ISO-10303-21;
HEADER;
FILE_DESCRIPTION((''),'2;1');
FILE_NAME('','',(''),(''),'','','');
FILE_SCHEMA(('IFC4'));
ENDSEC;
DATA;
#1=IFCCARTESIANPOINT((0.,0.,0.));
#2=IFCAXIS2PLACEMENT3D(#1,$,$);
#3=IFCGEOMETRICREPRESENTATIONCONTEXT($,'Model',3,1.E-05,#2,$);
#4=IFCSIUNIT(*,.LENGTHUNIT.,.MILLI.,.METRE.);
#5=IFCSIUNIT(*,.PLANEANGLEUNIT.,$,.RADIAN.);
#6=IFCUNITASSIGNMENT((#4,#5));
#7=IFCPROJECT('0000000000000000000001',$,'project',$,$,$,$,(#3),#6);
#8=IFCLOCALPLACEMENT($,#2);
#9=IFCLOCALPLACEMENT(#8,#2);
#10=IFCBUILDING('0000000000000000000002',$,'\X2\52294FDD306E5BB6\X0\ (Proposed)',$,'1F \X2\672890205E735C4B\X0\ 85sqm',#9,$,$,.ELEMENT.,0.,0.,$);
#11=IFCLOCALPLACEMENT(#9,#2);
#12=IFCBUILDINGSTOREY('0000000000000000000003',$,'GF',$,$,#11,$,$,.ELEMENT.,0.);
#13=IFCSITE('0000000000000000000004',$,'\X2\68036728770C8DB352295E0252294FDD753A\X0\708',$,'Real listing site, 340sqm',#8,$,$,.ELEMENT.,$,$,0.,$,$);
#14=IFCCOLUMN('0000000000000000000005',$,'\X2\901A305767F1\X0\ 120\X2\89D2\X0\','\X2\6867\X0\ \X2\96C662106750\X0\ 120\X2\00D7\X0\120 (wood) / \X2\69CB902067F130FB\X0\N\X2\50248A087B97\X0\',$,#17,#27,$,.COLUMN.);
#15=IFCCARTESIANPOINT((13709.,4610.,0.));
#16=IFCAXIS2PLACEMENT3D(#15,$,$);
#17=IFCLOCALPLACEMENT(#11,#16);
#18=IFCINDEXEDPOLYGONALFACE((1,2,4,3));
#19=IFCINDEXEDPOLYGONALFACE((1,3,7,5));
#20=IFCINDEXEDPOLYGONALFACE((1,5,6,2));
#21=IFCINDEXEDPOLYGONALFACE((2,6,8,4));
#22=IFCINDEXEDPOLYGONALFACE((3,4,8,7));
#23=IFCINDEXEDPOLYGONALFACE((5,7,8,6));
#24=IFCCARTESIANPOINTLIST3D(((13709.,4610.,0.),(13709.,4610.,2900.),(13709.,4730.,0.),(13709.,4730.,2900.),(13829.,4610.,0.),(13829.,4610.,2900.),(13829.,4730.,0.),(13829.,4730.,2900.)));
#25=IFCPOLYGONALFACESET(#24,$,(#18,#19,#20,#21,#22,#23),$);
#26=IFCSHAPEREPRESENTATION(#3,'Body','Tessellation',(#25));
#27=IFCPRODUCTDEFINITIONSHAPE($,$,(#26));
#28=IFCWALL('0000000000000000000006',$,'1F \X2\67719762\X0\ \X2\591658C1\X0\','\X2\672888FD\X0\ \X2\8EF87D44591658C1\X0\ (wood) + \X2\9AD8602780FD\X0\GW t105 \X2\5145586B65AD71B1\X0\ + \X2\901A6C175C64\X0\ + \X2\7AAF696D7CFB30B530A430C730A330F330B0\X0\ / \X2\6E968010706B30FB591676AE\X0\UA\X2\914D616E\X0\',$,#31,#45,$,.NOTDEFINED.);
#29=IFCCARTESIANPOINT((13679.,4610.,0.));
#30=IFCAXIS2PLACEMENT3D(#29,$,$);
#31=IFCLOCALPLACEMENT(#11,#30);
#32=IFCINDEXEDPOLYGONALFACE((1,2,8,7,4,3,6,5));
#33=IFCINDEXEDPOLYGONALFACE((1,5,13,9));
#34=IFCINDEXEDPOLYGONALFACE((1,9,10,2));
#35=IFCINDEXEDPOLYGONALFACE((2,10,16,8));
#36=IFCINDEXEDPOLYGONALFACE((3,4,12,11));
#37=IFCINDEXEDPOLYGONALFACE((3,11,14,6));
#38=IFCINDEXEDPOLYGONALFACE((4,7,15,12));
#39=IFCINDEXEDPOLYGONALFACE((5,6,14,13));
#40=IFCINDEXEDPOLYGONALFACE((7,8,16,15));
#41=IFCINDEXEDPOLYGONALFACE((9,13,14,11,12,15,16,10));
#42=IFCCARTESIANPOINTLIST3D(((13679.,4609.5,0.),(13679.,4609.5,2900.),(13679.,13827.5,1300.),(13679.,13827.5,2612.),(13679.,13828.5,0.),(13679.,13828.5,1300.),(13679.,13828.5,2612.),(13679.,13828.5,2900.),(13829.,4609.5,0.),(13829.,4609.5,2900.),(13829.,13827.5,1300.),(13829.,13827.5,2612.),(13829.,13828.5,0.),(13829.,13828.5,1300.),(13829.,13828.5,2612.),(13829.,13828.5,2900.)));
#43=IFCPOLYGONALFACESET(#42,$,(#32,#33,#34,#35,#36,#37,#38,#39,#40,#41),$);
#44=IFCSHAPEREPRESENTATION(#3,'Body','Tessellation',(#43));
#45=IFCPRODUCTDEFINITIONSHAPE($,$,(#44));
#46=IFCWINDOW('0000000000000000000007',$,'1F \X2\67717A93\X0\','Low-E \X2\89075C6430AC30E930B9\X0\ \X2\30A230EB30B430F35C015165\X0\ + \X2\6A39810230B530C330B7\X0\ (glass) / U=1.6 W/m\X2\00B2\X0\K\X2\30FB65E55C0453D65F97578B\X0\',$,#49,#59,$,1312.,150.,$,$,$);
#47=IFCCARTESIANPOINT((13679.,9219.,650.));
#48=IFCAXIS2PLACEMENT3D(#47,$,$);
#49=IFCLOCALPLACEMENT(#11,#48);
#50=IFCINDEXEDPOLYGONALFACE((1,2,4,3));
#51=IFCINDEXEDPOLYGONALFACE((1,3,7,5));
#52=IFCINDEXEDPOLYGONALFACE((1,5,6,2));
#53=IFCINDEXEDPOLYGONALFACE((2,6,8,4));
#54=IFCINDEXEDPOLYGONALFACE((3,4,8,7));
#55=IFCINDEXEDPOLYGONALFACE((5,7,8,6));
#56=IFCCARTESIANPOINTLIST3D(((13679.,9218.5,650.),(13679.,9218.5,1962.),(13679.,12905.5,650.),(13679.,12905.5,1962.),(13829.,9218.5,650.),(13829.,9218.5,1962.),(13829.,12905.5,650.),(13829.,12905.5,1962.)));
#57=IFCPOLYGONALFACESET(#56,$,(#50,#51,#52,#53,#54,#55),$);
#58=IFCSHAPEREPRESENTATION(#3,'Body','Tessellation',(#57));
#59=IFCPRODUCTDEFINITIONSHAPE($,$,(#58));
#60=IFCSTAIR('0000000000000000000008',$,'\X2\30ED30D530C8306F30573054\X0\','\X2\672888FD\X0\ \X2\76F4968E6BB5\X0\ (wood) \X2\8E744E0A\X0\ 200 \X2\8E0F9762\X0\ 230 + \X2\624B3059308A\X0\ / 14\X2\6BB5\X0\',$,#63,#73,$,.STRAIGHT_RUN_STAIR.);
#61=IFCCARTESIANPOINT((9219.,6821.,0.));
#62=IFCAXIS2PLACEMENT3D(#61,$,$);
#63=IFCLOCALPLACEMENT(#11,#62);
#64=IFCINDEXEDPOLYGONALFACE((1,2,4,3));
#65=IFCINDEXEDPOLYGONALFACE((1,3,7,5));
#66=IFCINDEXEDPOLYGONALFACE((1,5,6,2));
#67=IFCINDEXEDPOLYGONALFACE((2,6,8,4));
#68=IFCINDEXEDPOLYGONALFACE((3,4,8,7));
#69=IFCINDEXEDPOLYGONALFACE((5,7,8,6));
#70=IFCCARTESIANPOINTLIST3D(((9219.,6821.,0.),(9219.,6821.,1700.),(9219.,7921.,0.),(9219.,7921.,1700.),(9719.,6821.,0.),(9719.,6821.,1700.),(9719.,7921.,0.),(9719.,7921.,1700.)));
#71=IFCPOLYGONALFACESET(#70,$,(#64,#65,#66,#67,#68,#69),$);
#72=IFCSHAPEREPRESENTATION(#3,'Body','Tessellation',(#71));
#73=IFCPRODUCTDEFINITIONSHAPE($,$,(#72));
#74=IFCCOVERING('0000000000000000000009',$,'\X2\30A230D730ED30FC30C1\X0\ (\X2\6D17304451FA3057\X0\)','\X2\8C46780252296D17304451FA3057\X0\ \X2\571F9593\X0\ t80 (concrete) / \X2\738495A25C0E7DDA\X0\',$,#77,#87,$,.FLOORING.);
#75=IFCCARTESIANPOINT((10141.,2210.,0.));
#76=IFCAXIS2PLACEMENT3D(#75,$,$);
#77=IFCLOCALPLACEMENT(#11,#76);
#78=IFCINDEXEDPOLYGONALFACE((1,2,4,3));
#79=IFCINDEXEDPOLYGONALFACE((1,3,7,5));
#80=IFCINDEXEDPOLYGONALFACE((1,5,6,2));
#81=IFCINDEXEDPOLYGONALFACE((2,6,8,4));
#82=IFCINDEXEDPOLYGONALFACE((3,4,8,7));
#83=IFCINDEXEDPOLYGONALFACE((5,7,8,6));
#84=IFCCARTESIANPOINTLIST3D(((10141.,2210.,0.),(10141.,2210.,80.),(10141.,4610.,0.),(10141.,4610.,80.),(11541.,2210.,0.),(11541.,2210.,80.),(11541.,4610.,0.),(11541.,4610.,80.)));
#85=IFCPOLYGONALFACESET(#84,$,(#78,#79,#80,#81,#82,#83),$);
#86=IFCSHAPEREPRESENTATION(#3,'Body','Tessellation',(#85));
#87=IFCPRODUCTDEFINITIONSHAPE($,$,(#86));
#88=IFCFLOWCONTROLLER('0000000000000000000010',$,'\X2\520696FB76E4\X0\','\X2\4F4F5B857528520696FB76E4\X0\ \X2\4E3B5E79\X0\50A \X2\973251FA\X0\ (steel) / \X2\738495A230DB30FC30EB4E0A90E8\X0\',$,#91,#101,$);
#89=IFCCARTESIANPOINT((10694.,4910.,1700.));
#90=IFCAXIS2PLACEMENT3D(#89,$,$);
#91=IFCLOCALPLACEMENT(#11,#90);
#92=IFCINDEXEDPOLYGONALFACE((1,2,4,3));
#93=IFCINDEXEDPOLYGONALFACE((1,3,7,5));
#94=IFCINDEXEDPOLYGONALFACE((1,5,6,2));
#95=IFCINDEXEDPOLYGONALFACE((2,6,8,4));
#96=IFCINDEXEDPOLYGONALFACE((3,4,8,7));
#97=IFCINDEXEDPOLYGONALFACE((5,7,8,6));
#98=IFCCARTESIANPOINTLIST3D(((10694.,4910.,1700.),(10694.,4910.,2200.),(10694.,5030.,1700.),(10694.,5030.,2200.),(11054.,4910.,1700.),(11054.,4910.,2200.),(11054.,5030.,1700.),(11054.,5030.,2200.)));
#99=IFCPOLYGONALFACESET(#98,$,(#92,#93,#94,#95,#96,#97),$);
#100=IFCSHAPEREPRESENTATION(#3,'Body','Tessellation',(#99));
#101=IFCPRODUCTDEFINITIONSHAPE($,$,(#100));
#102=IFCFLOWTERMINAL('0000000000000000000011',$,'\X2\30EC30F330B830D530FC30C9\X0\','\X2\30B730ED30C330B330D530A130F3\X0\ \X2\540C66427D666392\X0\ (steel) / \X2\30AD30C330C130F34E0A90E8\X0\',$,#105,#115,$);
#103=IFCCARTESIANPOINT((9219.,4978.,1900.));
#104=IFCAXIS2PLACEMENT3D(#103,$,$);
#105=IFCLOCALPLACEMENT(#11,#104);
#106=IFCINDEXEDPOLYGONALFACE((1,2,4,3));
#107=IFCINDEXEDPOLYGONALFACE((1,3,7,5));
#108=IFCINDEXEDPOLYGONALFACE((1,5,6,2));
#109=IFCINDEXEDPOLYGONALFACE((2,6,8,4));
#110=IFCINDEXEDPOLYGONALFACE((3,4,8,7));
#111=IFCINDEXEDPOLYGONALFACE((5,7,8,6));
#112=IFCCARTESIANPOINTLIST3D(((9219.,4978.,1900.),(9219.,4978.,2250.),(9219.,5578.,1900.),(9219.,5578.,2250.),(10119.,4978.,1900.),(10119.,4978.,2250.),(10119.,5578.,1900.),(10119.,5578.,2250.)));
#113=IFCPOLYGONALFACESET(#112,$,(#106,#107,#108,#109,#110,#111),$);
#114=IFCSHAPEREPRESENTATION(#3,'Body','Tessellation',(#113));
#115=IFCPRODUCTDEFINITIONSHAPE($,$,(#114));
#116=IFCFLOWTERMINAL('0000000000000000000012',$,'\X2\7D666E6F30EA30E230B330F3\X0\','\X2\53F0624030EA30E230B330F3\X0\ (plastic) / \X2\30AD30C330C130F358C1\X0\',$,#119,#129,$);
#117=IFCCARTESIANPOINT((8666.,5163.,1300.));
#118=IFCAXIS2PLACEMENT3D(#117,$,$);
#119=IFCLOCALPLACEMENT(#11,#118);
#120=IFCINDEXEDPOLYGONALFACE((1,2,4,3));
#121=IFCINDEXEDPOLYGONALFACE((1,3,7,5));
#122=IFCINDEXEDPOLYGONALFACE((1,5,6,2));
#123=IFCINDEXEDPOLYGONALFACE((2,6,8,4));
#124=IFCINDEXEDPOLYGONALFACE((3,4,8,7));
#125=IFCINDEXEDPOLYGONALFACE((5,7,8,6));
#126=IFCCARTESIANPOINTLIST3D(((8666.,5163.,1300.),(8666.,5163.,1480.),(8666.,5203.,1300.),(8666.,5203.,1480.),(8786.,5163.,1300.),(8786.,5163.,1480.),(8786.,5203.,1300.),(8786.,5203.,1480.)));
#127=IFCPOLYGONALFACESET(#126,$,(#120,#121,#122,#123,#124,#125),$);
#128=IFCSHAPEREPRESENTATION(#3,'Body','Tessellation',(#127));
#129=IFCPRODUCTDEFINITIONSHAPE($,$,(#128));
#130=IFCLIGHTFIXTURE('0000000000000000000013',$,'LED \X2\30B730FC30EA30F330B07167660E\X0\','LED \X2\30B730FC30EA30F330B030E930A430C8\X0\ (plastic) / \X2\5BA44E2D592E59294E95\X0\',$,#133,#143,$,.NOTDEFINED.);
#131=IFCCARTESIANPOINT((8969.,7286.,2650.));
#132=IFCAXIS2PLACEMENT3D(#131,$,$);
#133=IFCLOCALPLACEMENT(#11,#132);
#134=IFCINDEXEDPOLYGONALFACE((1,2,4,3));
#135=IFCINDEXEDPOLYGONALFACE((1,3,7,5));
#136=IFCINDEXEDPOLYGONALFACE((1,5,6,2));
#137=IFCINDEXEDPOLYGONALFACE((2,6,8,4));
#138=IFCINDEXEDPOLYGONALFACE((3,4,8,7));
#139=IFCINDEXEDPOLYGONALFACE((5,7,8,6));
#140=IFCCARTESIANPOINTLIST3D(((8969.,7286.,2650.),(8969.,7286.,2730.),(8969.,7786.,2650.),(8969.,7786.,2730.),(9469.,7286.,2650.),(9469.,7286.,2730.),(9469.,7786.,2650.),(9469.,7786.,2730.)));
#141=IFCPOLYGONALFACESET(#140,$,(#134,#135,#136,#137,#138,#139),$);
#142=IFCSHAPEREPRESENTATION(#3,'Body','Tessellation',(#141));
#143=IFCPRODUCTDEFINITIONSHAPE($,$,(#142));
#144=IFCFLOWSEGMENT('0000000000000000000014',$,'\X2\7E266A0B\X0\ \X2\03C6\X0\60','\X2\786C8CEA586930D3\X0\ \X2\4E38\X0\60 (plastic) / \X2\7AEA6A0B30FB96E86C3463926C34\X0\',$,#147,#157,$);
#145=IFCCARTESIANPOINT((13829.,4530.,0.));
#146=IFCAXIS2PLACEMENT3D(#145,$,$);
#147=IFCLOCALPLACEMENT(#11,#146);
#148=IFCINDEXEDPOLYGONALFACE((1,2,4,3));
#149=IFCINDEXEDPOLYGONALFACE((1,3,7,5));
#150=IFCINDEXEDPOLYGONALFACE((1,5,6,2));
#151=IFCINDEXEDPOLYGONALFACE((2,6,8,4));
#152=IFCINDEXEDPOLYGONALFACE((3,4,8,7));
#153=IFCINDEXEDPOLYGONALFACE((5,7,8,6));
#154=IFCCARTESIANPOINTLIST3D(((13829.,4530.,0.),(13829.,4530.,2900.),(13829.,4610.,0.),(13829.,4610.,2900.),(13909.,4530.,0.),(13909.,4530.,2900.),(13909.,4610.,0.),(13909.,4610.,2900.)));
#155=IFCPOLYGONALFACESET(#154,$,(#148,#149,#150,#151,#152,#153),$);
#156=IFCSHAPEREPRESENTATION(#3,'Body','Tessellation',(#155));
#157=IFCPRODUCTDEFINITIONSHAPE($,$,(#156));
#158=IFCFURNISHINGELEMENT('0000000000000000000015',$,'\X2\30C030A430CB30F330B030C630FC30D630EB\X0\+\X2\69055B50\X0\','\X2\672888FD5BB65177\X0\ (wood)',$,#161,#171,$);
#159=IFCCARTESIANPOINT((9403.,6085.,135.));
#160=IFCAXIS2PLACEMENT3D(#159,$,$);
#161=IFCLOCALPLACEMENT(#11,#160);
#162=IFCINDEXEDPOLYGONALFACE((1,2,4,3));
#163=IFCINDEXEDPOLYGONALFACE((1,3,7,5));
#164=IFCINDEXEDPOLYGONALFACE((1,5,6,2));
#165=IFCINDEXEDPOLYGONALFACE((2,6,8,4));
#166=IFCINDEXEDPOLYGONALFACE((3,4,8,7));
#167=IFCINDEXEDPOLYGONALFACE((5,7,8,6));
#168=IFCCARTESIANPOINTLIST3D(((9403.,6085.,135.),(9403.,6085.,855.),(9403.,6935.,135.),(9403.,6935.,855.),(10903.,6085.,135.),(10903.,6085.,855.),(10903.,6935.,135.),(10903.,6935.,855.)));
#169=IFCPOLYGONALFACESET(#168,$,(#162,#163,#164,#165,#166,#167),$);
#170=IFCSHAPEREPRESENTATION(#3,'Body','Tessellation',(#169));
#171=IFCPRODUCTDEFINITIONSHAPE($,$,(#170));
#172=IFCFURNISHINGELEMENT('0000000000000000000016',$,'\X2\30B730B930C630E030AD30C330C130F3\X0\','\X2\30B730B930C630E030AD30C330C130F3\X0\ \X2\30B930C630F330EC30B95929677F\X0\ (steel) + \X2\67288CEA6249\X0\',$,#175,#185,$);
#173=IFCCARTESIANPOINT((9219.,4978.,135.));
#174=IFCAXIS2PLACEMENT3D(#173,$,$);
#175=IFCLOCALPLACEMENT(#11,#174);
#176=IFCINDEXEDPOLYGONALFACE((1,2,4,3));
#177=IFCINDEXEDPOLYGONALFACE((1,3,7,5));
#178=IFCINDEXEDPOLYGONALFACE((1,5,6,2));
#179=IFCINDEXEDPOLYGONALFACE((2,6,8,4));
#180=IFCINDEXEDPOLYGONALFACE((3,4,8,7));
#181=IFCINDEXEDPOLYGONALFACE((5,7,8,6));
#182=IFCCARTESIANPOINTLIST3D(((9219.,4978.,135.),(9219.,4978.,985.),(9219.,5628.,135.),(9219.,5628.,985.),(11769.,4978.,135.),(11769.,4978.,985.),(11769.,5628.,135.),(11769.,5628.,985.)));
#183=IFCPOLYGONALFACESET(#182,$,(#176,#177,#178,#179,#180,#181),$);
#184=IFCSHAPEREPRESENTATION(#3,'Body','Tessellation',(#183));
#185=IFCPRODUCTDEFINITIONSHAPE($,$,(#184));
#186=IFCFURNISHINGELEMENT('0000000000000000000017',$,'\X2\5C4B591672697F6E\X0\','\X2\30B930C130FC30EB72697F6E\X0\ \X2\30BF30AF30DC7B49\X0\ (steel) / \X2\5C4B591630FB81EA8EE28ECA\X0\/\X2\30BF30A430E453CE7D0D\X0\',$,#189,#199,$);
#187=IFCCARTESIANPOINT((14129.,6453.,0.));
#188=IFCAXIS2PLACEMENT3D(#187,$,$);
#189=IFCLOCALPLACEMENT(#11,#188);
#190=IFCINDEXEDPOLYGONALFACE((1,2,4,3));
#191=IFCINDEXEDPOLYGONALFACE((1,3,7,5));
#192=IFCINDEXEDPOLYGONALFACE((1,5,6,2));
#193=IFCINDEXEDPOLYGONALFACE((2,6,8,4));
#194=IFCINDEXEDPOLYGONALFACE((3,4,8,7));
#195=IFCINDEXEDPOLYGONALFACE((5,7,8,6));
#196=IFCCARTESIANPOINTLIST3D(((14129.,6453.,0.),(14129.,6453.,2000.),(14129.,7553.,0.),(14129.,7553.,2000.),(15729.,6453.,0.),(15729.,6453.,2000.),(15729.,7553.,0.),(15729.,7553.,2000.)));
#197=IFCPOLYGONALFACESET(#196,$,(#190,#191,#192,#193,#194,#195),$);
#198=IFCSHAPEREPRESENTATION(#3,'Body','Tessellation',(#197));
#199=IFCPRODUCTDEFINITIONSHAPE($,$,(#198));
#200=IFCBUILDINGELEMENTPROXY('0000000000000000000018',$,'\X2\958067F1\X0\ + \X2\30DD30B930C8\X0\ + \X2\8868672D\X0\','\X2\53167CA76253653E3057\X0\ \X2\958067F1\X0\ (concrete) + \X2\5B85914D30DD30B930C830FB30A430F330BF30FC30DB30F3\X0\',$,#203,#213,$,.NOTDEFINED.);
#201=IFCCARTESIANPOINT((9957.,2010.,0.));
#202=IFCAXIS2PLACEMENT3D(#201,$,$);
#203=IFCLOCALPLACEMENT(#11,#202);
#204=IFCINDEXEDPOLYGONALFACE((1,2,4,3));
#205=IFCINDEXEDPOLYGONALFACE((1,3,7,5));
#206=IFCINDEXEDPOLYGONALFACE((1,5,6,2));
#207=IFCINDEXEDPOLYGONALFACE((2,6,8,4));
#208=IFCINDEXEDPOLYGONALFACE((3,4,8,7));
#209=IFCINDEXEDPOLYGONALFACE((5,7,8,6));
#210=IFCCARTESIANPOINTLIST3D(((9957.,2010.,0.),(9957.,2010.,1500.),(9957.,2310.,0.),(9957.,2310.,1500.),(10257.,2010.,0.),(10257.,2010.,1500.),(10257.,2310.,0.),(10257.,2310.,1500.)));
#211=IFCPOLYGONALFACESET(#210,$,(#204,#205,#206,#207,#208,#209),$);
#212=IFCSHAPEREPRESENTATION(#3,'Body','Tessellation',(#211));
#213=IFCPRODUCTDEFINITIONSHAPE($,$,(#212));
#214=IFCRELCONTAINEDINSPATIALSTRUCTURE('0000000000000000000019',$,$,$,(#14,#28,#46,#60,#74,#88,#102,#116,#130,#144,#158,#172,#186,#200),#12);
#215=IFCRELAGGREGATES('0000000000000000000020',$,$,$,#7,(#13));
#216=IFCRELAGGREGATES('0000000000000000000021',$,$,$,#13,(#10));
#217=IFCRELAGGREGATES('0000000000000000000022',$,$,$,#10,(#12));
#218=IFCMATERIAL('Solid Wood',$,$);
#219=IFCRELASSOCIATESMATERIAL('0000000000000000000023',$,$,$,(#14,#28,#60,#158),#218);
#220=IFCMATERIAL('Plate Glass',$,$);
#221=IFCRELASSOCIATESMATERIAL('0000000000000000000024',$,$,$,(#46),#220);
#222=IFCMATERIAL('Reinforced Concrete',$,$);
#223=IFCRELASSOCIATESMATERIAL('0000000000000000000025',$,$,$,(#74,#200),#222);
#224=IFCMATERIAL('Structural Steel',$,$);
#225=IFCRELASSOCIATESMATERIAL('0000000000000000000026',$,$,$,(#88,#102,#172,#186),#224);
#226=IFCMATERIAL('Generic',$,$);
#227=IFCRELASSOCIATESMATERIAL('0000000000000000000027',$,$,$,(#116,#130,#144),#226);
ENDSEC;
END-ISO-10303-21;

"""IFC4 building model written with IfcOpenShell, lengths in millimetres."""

from ifc_helpers import new_model, si_unit, frame, frame_2d, origin, place, context, project, spatial, rectangle, extrude, material, element, fill, save


model = new_model("IFC4")

# Units and contexts
model_context = context("Model", 3, precision=1e-05, world=origin())
ifc_project = project(units=[si_unit("LENGTHUNIT", "METRE", prefix="MILLI"), si_unit("PLANEANGLEUNIT", "RADIAN")], contexts=[model_context])

# Site, building, storey
site_placement = place(None, origin())
site = spatial("IfcSite", under=ifc_project, at=site_placement, Name="栃木県足利市利保町708", ObjectType="Real listing site, 340sqm", CompositionType="ELEMENT", RefElevation=0.0)
building_placement = place(site_placement, origin())
building = spatial("IfcBuilding", under=site, at=building_placement, Name="利保の家 (Proposed)", ObjectType="1F 木造平屋 85sqm", CompositionType="ELEMENT", ElevationOfRefHeight=0.0, ElevationOfTerrain=0.0)
storey_placement = place(building_placement, origin())
storey = spatial("IfcBuildingStorey", under=building, at=storey_placement, Name="GF", CompositionType="ELEMENT", Elevation=0.0)

# Column
ifc_material_1 = material(Name="Solid Wood")
column_1_placement = place(storey_placement, frame((13709.0, 4610.0, 0.0)))
element("IfcColumn", 1, at=column_1_placement, inside=storey, material=ifc_material_1, Name="通し柱 120角", Description="桧 集成材 120×120 (wood) / 構造柱・N値計算", PredefinedType="COLUMN", context=model_context, shape_type="SweptSolid", body=[
    extrude(rectangle(XDim=120.0, YDim=120.0, at=frame_2d((60.0, 60.0))), frame((13709.0, 4610.0, 0.0)), (0.0, 0.0, 1.0), 2900.0),
])

# Wall, opening, window
wall_1_placement = place(storey_placement, frame((13679.0, 4610.0, 0.0)))
wall_1 = element("IfcWall", 2, at=wall_1_placement, inside=storey, material=ifc_material_1, Name="1F 東面 外壁", Description="木製 軸組外壁 (wood) + 高性能GW t105 充填断熱 + 通気層 + 窯業系サイディング / 準耐火・外皮UA配慮", PredefinedType="NOTDEFINED", context=model_context, shape_type="SweptSolid", body=[
    extrude(rectangle(XDim=150.0, YDim=9219.0, at=frame_2d((75.0, 4609.0))), frame((13679.0, 4610.0, 0.0)), (0.0, 0.0, 1.0), 2900.0),
])
opening_placement = place(storey_placement, frame((13679.0, 9219.0, 650.0)))
opening = element("IfcOpeningElement", 3, at=opening_placement, cuts=wall_1, PredefinedType="NOTDEFINED", context=model_context, shape_type="SweptSolid", body=[
    extrude(rectangle(XDim=150.0, YDim=3687.0, at=frame_2d((75.0, 1843.0))), frame((13679.0, 9219.0, 650.0)), (0.0, 0.0, 1.0), 1312.0),
])
ifc_material_2 = material(Name="Plate Glass")
window_placement = place(storey_placement, frame((13679.0, 9219.0, 650.0)))
window = element("IfcWindow", 4, at=window_placement, inside=storey, material=ifc_material_2, Name="1F 東窓", Description="Low-E 複層ガラス アルゴン封入 + 樹脂サッシ (glass) / U=1.6 W/m²K・日射取得型", OverallHeight=1312.0, OverallWidth=150.0, context=model_context, shape_type="SweptSolid", body=[
    extrude(rectangle(XDim=150.0, YDim=3687.0, at=frame_2d((75.0, 1843.0))), frame((13679.0, 9219.0, 650.0)), (0.0, 0.0, 1.0), 1312.0),
])
fill(opening, window)

# Stair
stair_placement = place(storey_placement, frame((9219.0, 6821.0, 0.0)))
element("IfcStair", 5, at=stair_placement, inside=storey, material=ifc_material_1, Name="ロフトはしご", Description="木製 直階段 (wood) 蹴上 200 踏面 230 + 手すり / 14段", PredefinedType="STRAIGHT_RUN_STAIR", context=model_context, shape_type="SweptSolid", body=[
    extrude(rectangle(XDim=500.0, YDim=1100.0, at=frame_2d((250.0, 550.0))), frame((9219.0, 6821.0, 0.0)), (0.0, 0.0, 1.0), 1700.0),
])

# Covering
ifc_material_3 = material(Name="Reinforced Concrete")
covering_placement = place(storey_placement, frame((10141.0, 2210.0, 0.0)))
element("IfcCovering", 6, at=covering_placement, inside=storey, material=ifc_material_3, Name="アプローチ (洗い出し)", Description="豆砂利洗い出し 土間 t80 (concrete) / 玄関導線", PredefinedType="FLOORING", context=model_context, shape_type="SweptSolid", body=[
    extrude(rectangle(XDim=1400.0, YDim=2400.0, at=frame_2d((700.0, 1200.0))), frame((10141.0, 2210.0, 0.0)), (0.0, 0.0, 1.0), 80.0),
])

# Flow controller
ifc_material_4 = material(Name="Structural Steel")
flow_controller_placement = place(storey_placement, frame((10694.0, 4910.0, 1700.0)))
element("IfcFlowController", 7, at=flow_controller_placement, inside=storey, material=ifc_material_4, Name="分電盤", Description="住宅用分電盤 主幹50A 露出 (steel) / 玄関ホール上部", context=model_context, shape_type="SweptSolid", body=[
    extrude(rectangle(XDim=360.0, YDim=120.0, at=frame_2d((180.0, 60.0))), frame((10694.0, 4910.0, 1700.0)), (0.0, 0.0, 1.0), 500.0),
])

# Flow terminals
flow_terminal_1_placement = place(storey_placement, frame((9219.0, 4978.0, 1900.0)))
element("IfcFlowTerminal", 8, at=flow_terminal_1_placement, inside=storey, material=ifc_material_4, Name="レンジフード", Description="シロッコファン 同時給排 (steel) / キッチン上部", context=model_context, shape_type="SweptSolid", body=[
    extrude(rectangle(XDim=900.0, YDim=600.0, at=frame_2d((450.0, 300.0))), frame((9219.0, 4978.0, 1900.0)), (0.0, 0.0, 1.0), 350.0),
])
ifc_material_5 = material(Name="Generic")
flow_terminal_2_placement = place(storey_placement, frame((8666.0, 5163.0, 1300.0)))
element("IfcFlowTerminal", 9, at=flow_terminal_2_placement, inside=storey, material=ifc_material_5, Name="給湯リモコン", Description="台所リモコン (plastic) / キッチン壁", context=model_context, shape_type="SweptSolid", body=[
    extrude(rectangle(XDim=120.0, YDim=40.0, at=frame_2d((60.0, 20.0))), frame((8666.0, 5163.0, 1300.0)), (0.0, 0.0, 1.0), 180.0),
])

# Light fixture
light_fixture_placement = place(storey_placement, frame((8969.0, 7286.0, 2650.0)))
element("IfcLightFixture", 10, at=light_fixture_placement, inside=storey, material=ifc_material_5, Name="LED シーリング照明", Description="LED シーリングライト (plastic) / 室中央天井", PredefinedType="NOTDEFINED", context=model_context, shape_type="SweptSolid", body=[
    extrude(rectangle(XDim=500.0, YDim=500.0, at=frame_2d((250.0, 250.0))), frame((8969.0, 7286.0, 2650.0)), (0.0, 0.0, 1.0), 80.0),
])

# Flow segment
flow_segment_placement = place(storey_placement, frame((13829.0, 4530.0, 0.0)))
element("IfcFlowSegment", 11, at=flow_segment_placement, inside=storey, material=ifc_material_5, Name="縦樋 φ60", Description="硬質塩ビ 丸60 (plastic) / 竪樋・雨水排水", context=model_context, shape_type="SweptSolid", body=[
    extrude(rectangle(XDim=80.0, YDim=80.0, at=frame_2d((40.0, 40.0))), frame((13829.0, 4530.0, 0.0)), (0.0, 0.0, 1.0), 2900.0),
])

# Furnishing elements
furnishing_1_placement = place(storey_placement, frame((9403.0, 6085.0, 135.0)))
element("IfcFurnishingElement", 12, at=furnishing_1_placement, inside=storey, material=ifc_material_1, Name="ダイニングテーブル+椅子", Description="木製家具 (wood)", context=model_context, shape_type="SweptSolid", body=[
    extrude(rectangle(XDim=1500.0, YDim=850.0, at=frame_2d((750.0, 425.0))), frame((9403.0, 6085.0, 135.0)), (0.0, 0.0, 1.0), 720.0),
])
furnishing_2_placement = place(storey_placement, frame((9219.0, 4978.0, 135.0)))
element("IfcFurnishingElement", 13, at=furnishing_2_placement, inside=storey, material=ifc_material_4, Name="システムキッチン", Description="システムキッチン ステンレス天板 (steel) + 木質扉", context=model_context, shape_type="SweptSolid", body=[
    extrude(rectangle(XDim=2550.0, YDim=650.0, at=frame_2d((1275.0, 325.0))), frame((9219.0, 4978.0, 135.0)), (0.0, 0.0, 1.0), 850.0),
])
furnishing_3_placement = place(storey_placement, frame((14129.0, 6453.0, 0.0)))
element("IfcFurnishingElement", 14, at=furnishing_3_placement, inside=storey, material=ifc_material_4, Name="屋外物置", Description="スチール物置 タクボ等 (steel) / 屋外・自転車/タイヤ収納", context=model_context, shape_type="SweptSolid", body=[
    extrude(rectangle(XDim=1600.0, YDim=1100.0, at=frame_2d((800.0, 550.0))), frame((14129.0, 6453.0, 0.0)), (0.0, 0.0, 1.0), 2000.0),
])

# Building element proxy
proxy_placement = place(storey_placement, frame((9957.0, 2010.0, 0.0)))
element("IfcBuildingElementProxy", 15, at=proxy_placement, inside=storey, material=ifc_material_3, Name="門柱 + ポスト + 表札", Description="化粧打放し 門柱 (concrete) + 宅配ポスト・インターホン", PredefinedType="NOTDEFINED", context=model_context, shape_type="SweptSolid", body=[
    extrude(rectangle(XDim=300.0, YDim=300.0, at=frame_2d((150.0, 150.0))), frame((9957.0, 2010.0, 0.0)), (0.0, 0.0, 1.0), 1500.0),
])

save(model, "model.ifc")
